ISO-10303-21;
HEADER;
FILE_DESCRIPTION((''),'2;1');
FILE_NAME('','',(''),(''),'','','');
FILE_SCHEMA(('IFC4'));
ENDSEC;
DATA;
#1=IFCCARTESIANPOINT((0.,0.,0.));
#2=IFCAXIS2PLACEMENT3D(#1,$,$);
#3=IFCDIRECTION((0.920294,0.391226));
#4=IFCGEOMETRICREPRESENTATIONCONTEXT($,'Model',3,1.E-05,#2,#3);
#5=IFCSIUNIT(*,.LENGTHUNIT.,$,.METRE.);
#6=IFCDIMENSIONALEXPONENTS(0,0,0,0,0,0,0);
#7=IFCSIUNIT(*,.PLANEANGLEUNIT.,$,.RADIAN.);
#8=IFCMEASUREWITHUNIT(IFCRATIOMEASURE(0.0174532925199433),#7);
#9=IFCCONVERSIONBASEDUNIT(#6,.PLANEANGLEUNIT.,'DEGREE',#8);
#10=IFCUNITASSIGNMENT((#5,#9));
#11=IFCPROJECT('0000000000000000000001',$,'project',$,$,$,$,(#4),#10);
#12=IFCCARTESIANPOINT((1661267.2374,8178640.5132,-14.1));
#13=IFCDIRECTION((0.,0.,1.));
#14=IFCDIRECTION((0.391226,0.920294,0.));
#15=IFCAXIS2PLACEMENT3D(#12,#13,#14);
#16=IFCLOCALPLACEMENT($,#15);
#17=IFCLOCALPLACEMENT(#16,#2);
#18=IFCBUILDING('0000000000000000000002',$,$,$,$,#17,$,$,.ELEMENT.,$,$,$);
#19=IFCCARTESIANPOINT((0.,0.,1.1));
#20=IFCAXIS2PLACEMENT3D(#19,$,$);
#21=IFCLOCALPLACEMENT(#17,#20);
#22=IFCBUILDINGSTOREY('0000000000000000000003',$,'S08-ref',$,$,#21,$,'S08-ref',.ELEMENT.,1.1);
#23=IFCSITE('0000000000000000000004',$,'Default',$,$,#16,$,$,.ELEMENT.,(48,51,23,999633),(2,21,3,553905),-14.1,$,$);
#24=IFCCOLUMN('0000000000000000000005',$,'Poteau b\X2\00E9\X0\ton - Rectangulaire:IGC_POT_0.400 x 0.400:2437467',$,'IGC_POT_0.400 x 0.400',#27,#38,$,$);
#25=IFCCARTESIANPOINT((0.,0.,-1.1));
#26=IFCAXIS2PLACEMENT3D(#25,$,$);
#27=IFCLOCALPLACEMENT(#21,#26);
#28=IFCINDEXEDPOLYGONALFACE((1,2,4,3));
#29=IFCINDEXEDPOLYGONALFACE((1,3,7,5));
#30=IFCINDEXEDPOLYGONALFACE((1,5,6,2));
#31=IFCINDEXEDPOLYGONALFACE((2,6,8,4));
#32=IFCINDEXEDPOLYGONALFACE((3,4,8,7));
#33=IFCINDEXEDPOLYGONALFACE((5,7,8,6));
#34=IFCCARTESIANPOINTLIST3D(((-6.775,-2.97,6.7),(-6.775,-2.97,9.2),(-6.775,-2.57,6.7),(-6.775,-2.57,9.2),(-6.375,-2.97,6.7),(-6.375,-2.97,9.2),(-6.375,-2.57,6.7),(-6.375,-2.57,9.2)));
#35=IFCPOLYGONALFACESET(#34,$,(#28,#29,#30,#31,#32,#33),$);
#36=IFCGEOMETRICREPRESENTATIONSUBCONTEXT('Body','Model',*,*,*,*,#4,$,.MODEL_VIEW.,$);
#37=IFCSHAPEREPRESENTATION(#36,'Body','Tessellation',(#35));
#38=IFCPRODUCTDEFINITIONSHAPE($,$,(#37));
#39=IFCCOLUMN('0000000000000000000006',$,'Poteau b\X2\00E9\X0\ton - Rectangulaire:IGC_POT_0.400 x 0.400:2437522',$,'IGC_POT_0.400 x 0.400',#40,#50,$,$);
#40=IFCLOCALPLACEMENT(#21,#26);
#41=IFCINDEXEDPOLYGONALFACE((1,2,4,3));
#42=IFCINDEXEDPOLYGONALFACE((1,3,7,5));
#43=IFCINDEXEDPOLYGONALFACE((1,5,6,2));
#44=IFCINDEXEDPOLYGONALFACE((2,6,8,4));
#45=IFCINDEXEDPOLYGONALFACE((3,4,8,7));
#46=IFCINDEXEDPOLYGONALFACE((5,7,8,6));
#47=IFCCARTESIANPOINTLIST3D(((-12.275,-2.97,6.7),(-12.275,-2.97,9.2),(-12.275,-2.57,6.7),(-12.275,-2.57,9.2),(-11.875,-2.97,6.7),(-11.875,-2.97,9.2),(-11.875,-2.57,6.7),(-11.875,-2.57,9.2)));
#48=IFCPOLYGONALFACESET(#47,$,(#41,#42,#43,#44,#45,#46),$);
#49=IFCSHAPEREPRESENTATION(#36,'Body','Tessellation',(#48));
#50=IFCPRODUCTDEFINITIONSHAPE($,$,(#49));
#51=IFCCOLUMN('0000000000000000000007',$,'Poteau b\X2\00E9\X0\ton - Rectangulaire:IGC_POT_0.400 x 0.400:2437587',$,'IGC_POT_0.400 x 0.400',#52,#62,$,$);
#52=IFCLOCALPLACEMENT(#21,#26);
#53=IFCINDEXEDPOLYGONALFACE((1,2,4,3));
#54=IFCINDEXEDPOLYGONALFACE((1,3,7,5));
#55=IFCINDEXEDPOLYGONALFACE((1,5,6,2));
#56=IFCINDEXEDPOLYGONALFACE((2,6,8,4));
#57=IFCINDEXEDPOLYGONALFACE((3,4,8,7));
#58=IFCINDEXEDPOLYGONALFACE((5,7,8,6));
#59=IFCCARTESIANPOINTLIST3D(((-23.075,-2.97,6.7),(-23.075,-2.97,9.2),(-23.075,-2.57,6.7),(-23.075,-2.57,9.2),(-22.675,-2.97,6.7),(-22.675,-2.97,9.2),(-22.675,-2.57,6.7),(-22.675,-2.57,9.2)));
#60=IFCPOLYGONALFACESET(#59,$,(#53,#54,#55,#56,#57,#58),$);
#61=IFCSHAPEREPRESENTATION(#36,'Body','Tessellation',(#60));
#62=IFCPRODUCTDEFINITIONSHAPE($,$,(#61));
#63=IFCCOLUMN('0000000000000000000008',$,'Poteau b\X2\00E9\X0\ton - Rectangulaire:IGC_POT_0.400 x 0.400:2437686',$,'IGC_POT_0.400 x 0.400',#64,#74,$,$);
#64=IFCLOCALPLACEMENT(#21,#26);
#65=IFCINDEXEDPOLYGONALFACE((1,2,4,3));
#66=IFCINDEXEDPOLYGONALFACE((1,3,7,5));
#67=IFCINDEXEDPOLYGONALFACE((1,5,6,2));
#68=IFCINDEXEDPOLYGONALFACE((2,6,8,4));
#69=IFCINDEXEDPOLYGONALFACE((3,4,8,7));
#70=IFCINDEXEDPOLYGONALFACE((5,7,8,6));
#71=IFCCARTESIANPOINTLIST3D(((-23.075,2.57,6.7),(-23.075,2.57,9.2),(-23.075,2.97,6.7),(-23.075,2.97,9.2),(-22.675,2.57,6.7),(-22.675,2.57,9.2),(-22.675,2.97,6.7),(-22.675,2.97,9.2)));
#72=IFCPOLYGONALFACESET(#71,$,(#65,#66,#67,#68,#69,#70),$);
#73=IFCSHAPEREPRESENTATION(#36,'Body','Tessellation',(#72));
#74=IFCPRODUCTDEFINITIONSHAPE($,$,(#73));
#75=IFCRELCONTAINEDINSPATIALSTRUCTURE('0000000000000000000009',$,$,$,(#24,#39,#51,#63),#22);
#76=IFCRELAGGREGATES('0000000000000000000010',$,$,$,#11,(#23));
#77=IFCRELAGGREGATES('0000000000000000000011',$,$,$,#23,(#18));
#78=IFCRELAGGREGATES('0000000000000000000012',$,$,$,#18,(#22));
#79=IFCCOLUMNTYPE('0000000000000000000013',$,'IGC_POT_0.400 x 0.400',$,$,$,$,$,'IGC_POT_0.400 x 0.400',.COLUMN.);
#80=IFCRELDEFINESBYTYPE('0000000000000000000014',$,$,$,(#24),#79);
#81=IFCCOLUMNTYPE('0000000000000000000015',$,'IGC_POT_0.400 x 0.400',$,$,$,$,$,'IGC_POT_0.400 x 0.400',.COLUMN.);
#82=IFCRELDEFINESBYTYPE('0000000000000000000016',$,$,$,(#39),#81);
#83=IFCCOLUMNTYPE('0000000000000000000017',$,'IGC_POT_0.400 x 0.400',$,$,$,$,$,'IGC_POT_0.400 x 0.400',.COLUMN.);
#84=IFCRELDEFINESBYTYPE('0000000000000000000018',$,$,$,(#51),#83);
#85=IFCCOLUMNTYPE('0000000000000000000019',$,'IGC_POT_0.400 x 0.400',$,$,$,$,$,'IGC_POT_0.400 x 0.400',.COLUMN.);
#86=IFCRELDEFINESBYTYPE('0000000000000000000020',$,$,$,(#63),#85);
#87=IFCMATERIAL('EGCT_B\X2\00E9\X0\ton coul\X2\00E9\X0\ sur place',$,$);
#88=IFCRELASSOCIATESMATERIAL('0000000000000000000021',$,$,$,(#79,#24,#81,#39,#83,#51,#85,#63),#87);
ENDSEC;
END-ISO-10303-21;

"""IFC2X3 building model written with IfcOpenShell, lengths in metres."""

from ifc_helpers import new_model, entity, si_unit, converted_unit, direction, frame, frame_2d, origin, origin_2d_with_axis, place, context, subcontext, project, spatial, rectangle, extrude, source, transform, mapped, material, type_object, type_shapes, element, save


model = new_model("IFC2X3")

# Units and contexts
model_context = context("Model", 3, precision=1e-05, world=origin(), true_north=direction((0.920294, 0.391226)))
body_context = subcontext(model_context, "Body", "Model", "MODEL_VIEW")
ifc_project = project(units=[si_unit("LENGTHUNIT", "METRE"), converted_unit("PLANEANGLEUNIT", "DEGREE", entity("IfcRatioMeasure", 0.0174532925199433), si_unit("PLANEANGLEUNIT", "RADIAN"), dimensions=[0, 0, 0, 0, 0, 0, 0])], contexts=[model_context])

# Site, building, storey
site_placement = place(None, frame((1661267.2374, 8178640.5132, -14.1), z_axis=(0.0, 0.0, 1.0), x_axis=(0.391226, 0.920294, 0.0)))
site = spatial("IfcSite", under=ifc_project, at=site_placement, Name="Default", CompositionType="ELEMENT", RefLatitude=(48, 51, 23, 999633), RefLongitude=(2, 21, 3, 553905), RefElevation=-14.1)
building_placement = place(site_placement, origin())
building = spatial("IfcBuilding", under=site, at=building_placement, CompositionType="ELEMENT")
storey_placement = place(building_placement, frame((0.0, 0.0, 1.1)))
storey = spatial("IfcBuildingStorey", under=building, at=storey_placement, Name="S08-ref", LongName="S08-ref", CompositionType="ELEMENT", Elevation=1.1)

# Columns
ifc_material_1 = material(Name="EGCT_Béton coulé sur place")
column_type_1 = type_object("IfcColumnType", Name="IGC_POT_0.400 x 0.400", ElementType="IGC_POT_0.400 x 0.400", PredefinedType="COLUMN", material=ifc_material_1)
shared_shape_1 = source(origin(), body_context, "Body", "SweptSolid", [
    extrude(rectangle(XDim=0.4, YDim=0.4, at=origin_2d_with_axis()), frame((-6.575, -2.77, 6.7), z_axis=(0.0, 0.0, 1.0), x_axis=(0.0, -1.0, 0.0)), (0.0, 0.0, 1.0), 2.5),
])
type_shapes(column_type_1, [shared_shape_1])
column_1_placement = place(storey_placement, frame((0.0, 0.0, -1.1)))
element("IfcColumn", 1, at=column_1_placement, inside=storey, type_object=column_type_1, material=ifc_material_1, Name="Poteau béton - Rectangulaire:IGC_POT_0.400 x 0.400:2437467", ObjectType="IGC_POT_0.400 x 0.400", context=body_context, shape_type="MappedRepresentation", body=[
    mapped(shared_shape_1, transform((0.0, 0.0, 0.0), scale=1.0)),
])
column_type_2 = type_object("IfcColumnType", Name="IGC_POT_0.400 x 0.400", ElementType="IGC_POT_0.400 x 0.400", PredefinedType="COLUMN", material=ifc_material_1)
shared_shape_2 = source(origin(), body_context, "Body", "SweptSolid", [
    extrude(rectangle(XDim=0.4, YDim=0.4, at=origin_2d_with_axis()), frame((-12.075, -2.77, 6.7), z_axis=(0.0, 0.0, 1.0), x_axis=(0.0, -1.0, 0.0)), (0.0, 0.0, 1.0), 2.5),
])
type_shapes(column_type_2, [shared_shape_2])
column_2_placement = place(storey_placement, frame((0.0, 0.0, -1.1)))
element("IfcColumn", 2, at=column_2_placement, inside=storey, type_object=column_type_2, material=ifc_material_1, Name="Poteau béton - Rectangulaire:IGC_POT_0.400 x 0.400:2437522", ObjectType="IGC_POT_0.400 x 0.400", context=body_context, shape_type="MappedRepresentation", body=[
    mapped(shared_shape_2, transform((0.0, 0.0, 0.0), scale=1.0)),
])
column_type_3 = type_object("IfcColumnType", Name="IGC_POT_0.400 x 0.400", ElementType="IGC_POT_0.400 x 0.400", PredefinedType="COLUMN", material=ifc_material_1)
shared_shape_3 = source(origin(), body_context, "Body", "SweptSolid", [
    extrude(rectangle(XDim=0.4, YDim=0.4, at=frame_2d((0.0, 0.0), x_axis=(1.0, 0.0))), frame((-22.875, -2.77, 6.7), z_axis=(0.0, 0.0, 1.0), x_axis=(0.0, -1.0, 0.0)), (0.0, 0.0, 1.0), 2.5),
])
type_shapes(column_type_3, [shared_shape_3])
column_3_placement = place(storey_placement, frame((0.0, 0.0, -1.1)))
element("IfcColumn", 3, at=column_3_placement, inside=storey, type_object=column_type_3, material=ifc_material_1, Name="Poteau béton - Rectangulaire:IGC_POT_0.400 x 0.400:2437587", ObjectType="IGC_POT_0.400 x 0.400", context=body_context, shape_type="MappedRepresentation", body=[
    mapped(shared_shape_3, transform((0.0, 0.0, 0.0), scale=1.0)),
])
column_type_4 = type_object("IfcColumnType", Name="IGC_POT_0.400 x 0.400", ElementType="IGC_POT_0.400 x 0.400", PredefinedType="COLUMN", material=ifc_material_1)
shared_shape_4 = source(origin(), body_context, "Body", "SweptSolid", [
    extrude(rectangle(XDim=0.4, YDim=0.4, at=frame_2d((0.0, 0.0), x_axis=(1.0, 0.0))), frame((-22.875, 2.77, 6.7), z_axis=(0.0, 0.0, 1.0), x_axis=(0.0, -1.0, 0.0)), (0.0, 0.0, 1.0), 2.5),
])
type_shapes(column_type_4, [shared_shape_4])
column_4_placement = place(storey_placement, frame((0.0, 0.0, -1.1)))
element("IfcColumn", 4, at=column_4_placement, inside=storey, type_object=column_type_4, material=ifc_material_1, Name="Poteau béton - Rectangulaire:IGC_POT_0.400 x 0.400:2437686", ObjectType="IGC_POT_0.400 x 0.400", context=body_context, shape_type="MappedRepresentation", body=[
    mapped(shared_shape_4, transform((0.0, 0.0, 0.0), scale=1.0)),
])

save(model, "model.ifc")
